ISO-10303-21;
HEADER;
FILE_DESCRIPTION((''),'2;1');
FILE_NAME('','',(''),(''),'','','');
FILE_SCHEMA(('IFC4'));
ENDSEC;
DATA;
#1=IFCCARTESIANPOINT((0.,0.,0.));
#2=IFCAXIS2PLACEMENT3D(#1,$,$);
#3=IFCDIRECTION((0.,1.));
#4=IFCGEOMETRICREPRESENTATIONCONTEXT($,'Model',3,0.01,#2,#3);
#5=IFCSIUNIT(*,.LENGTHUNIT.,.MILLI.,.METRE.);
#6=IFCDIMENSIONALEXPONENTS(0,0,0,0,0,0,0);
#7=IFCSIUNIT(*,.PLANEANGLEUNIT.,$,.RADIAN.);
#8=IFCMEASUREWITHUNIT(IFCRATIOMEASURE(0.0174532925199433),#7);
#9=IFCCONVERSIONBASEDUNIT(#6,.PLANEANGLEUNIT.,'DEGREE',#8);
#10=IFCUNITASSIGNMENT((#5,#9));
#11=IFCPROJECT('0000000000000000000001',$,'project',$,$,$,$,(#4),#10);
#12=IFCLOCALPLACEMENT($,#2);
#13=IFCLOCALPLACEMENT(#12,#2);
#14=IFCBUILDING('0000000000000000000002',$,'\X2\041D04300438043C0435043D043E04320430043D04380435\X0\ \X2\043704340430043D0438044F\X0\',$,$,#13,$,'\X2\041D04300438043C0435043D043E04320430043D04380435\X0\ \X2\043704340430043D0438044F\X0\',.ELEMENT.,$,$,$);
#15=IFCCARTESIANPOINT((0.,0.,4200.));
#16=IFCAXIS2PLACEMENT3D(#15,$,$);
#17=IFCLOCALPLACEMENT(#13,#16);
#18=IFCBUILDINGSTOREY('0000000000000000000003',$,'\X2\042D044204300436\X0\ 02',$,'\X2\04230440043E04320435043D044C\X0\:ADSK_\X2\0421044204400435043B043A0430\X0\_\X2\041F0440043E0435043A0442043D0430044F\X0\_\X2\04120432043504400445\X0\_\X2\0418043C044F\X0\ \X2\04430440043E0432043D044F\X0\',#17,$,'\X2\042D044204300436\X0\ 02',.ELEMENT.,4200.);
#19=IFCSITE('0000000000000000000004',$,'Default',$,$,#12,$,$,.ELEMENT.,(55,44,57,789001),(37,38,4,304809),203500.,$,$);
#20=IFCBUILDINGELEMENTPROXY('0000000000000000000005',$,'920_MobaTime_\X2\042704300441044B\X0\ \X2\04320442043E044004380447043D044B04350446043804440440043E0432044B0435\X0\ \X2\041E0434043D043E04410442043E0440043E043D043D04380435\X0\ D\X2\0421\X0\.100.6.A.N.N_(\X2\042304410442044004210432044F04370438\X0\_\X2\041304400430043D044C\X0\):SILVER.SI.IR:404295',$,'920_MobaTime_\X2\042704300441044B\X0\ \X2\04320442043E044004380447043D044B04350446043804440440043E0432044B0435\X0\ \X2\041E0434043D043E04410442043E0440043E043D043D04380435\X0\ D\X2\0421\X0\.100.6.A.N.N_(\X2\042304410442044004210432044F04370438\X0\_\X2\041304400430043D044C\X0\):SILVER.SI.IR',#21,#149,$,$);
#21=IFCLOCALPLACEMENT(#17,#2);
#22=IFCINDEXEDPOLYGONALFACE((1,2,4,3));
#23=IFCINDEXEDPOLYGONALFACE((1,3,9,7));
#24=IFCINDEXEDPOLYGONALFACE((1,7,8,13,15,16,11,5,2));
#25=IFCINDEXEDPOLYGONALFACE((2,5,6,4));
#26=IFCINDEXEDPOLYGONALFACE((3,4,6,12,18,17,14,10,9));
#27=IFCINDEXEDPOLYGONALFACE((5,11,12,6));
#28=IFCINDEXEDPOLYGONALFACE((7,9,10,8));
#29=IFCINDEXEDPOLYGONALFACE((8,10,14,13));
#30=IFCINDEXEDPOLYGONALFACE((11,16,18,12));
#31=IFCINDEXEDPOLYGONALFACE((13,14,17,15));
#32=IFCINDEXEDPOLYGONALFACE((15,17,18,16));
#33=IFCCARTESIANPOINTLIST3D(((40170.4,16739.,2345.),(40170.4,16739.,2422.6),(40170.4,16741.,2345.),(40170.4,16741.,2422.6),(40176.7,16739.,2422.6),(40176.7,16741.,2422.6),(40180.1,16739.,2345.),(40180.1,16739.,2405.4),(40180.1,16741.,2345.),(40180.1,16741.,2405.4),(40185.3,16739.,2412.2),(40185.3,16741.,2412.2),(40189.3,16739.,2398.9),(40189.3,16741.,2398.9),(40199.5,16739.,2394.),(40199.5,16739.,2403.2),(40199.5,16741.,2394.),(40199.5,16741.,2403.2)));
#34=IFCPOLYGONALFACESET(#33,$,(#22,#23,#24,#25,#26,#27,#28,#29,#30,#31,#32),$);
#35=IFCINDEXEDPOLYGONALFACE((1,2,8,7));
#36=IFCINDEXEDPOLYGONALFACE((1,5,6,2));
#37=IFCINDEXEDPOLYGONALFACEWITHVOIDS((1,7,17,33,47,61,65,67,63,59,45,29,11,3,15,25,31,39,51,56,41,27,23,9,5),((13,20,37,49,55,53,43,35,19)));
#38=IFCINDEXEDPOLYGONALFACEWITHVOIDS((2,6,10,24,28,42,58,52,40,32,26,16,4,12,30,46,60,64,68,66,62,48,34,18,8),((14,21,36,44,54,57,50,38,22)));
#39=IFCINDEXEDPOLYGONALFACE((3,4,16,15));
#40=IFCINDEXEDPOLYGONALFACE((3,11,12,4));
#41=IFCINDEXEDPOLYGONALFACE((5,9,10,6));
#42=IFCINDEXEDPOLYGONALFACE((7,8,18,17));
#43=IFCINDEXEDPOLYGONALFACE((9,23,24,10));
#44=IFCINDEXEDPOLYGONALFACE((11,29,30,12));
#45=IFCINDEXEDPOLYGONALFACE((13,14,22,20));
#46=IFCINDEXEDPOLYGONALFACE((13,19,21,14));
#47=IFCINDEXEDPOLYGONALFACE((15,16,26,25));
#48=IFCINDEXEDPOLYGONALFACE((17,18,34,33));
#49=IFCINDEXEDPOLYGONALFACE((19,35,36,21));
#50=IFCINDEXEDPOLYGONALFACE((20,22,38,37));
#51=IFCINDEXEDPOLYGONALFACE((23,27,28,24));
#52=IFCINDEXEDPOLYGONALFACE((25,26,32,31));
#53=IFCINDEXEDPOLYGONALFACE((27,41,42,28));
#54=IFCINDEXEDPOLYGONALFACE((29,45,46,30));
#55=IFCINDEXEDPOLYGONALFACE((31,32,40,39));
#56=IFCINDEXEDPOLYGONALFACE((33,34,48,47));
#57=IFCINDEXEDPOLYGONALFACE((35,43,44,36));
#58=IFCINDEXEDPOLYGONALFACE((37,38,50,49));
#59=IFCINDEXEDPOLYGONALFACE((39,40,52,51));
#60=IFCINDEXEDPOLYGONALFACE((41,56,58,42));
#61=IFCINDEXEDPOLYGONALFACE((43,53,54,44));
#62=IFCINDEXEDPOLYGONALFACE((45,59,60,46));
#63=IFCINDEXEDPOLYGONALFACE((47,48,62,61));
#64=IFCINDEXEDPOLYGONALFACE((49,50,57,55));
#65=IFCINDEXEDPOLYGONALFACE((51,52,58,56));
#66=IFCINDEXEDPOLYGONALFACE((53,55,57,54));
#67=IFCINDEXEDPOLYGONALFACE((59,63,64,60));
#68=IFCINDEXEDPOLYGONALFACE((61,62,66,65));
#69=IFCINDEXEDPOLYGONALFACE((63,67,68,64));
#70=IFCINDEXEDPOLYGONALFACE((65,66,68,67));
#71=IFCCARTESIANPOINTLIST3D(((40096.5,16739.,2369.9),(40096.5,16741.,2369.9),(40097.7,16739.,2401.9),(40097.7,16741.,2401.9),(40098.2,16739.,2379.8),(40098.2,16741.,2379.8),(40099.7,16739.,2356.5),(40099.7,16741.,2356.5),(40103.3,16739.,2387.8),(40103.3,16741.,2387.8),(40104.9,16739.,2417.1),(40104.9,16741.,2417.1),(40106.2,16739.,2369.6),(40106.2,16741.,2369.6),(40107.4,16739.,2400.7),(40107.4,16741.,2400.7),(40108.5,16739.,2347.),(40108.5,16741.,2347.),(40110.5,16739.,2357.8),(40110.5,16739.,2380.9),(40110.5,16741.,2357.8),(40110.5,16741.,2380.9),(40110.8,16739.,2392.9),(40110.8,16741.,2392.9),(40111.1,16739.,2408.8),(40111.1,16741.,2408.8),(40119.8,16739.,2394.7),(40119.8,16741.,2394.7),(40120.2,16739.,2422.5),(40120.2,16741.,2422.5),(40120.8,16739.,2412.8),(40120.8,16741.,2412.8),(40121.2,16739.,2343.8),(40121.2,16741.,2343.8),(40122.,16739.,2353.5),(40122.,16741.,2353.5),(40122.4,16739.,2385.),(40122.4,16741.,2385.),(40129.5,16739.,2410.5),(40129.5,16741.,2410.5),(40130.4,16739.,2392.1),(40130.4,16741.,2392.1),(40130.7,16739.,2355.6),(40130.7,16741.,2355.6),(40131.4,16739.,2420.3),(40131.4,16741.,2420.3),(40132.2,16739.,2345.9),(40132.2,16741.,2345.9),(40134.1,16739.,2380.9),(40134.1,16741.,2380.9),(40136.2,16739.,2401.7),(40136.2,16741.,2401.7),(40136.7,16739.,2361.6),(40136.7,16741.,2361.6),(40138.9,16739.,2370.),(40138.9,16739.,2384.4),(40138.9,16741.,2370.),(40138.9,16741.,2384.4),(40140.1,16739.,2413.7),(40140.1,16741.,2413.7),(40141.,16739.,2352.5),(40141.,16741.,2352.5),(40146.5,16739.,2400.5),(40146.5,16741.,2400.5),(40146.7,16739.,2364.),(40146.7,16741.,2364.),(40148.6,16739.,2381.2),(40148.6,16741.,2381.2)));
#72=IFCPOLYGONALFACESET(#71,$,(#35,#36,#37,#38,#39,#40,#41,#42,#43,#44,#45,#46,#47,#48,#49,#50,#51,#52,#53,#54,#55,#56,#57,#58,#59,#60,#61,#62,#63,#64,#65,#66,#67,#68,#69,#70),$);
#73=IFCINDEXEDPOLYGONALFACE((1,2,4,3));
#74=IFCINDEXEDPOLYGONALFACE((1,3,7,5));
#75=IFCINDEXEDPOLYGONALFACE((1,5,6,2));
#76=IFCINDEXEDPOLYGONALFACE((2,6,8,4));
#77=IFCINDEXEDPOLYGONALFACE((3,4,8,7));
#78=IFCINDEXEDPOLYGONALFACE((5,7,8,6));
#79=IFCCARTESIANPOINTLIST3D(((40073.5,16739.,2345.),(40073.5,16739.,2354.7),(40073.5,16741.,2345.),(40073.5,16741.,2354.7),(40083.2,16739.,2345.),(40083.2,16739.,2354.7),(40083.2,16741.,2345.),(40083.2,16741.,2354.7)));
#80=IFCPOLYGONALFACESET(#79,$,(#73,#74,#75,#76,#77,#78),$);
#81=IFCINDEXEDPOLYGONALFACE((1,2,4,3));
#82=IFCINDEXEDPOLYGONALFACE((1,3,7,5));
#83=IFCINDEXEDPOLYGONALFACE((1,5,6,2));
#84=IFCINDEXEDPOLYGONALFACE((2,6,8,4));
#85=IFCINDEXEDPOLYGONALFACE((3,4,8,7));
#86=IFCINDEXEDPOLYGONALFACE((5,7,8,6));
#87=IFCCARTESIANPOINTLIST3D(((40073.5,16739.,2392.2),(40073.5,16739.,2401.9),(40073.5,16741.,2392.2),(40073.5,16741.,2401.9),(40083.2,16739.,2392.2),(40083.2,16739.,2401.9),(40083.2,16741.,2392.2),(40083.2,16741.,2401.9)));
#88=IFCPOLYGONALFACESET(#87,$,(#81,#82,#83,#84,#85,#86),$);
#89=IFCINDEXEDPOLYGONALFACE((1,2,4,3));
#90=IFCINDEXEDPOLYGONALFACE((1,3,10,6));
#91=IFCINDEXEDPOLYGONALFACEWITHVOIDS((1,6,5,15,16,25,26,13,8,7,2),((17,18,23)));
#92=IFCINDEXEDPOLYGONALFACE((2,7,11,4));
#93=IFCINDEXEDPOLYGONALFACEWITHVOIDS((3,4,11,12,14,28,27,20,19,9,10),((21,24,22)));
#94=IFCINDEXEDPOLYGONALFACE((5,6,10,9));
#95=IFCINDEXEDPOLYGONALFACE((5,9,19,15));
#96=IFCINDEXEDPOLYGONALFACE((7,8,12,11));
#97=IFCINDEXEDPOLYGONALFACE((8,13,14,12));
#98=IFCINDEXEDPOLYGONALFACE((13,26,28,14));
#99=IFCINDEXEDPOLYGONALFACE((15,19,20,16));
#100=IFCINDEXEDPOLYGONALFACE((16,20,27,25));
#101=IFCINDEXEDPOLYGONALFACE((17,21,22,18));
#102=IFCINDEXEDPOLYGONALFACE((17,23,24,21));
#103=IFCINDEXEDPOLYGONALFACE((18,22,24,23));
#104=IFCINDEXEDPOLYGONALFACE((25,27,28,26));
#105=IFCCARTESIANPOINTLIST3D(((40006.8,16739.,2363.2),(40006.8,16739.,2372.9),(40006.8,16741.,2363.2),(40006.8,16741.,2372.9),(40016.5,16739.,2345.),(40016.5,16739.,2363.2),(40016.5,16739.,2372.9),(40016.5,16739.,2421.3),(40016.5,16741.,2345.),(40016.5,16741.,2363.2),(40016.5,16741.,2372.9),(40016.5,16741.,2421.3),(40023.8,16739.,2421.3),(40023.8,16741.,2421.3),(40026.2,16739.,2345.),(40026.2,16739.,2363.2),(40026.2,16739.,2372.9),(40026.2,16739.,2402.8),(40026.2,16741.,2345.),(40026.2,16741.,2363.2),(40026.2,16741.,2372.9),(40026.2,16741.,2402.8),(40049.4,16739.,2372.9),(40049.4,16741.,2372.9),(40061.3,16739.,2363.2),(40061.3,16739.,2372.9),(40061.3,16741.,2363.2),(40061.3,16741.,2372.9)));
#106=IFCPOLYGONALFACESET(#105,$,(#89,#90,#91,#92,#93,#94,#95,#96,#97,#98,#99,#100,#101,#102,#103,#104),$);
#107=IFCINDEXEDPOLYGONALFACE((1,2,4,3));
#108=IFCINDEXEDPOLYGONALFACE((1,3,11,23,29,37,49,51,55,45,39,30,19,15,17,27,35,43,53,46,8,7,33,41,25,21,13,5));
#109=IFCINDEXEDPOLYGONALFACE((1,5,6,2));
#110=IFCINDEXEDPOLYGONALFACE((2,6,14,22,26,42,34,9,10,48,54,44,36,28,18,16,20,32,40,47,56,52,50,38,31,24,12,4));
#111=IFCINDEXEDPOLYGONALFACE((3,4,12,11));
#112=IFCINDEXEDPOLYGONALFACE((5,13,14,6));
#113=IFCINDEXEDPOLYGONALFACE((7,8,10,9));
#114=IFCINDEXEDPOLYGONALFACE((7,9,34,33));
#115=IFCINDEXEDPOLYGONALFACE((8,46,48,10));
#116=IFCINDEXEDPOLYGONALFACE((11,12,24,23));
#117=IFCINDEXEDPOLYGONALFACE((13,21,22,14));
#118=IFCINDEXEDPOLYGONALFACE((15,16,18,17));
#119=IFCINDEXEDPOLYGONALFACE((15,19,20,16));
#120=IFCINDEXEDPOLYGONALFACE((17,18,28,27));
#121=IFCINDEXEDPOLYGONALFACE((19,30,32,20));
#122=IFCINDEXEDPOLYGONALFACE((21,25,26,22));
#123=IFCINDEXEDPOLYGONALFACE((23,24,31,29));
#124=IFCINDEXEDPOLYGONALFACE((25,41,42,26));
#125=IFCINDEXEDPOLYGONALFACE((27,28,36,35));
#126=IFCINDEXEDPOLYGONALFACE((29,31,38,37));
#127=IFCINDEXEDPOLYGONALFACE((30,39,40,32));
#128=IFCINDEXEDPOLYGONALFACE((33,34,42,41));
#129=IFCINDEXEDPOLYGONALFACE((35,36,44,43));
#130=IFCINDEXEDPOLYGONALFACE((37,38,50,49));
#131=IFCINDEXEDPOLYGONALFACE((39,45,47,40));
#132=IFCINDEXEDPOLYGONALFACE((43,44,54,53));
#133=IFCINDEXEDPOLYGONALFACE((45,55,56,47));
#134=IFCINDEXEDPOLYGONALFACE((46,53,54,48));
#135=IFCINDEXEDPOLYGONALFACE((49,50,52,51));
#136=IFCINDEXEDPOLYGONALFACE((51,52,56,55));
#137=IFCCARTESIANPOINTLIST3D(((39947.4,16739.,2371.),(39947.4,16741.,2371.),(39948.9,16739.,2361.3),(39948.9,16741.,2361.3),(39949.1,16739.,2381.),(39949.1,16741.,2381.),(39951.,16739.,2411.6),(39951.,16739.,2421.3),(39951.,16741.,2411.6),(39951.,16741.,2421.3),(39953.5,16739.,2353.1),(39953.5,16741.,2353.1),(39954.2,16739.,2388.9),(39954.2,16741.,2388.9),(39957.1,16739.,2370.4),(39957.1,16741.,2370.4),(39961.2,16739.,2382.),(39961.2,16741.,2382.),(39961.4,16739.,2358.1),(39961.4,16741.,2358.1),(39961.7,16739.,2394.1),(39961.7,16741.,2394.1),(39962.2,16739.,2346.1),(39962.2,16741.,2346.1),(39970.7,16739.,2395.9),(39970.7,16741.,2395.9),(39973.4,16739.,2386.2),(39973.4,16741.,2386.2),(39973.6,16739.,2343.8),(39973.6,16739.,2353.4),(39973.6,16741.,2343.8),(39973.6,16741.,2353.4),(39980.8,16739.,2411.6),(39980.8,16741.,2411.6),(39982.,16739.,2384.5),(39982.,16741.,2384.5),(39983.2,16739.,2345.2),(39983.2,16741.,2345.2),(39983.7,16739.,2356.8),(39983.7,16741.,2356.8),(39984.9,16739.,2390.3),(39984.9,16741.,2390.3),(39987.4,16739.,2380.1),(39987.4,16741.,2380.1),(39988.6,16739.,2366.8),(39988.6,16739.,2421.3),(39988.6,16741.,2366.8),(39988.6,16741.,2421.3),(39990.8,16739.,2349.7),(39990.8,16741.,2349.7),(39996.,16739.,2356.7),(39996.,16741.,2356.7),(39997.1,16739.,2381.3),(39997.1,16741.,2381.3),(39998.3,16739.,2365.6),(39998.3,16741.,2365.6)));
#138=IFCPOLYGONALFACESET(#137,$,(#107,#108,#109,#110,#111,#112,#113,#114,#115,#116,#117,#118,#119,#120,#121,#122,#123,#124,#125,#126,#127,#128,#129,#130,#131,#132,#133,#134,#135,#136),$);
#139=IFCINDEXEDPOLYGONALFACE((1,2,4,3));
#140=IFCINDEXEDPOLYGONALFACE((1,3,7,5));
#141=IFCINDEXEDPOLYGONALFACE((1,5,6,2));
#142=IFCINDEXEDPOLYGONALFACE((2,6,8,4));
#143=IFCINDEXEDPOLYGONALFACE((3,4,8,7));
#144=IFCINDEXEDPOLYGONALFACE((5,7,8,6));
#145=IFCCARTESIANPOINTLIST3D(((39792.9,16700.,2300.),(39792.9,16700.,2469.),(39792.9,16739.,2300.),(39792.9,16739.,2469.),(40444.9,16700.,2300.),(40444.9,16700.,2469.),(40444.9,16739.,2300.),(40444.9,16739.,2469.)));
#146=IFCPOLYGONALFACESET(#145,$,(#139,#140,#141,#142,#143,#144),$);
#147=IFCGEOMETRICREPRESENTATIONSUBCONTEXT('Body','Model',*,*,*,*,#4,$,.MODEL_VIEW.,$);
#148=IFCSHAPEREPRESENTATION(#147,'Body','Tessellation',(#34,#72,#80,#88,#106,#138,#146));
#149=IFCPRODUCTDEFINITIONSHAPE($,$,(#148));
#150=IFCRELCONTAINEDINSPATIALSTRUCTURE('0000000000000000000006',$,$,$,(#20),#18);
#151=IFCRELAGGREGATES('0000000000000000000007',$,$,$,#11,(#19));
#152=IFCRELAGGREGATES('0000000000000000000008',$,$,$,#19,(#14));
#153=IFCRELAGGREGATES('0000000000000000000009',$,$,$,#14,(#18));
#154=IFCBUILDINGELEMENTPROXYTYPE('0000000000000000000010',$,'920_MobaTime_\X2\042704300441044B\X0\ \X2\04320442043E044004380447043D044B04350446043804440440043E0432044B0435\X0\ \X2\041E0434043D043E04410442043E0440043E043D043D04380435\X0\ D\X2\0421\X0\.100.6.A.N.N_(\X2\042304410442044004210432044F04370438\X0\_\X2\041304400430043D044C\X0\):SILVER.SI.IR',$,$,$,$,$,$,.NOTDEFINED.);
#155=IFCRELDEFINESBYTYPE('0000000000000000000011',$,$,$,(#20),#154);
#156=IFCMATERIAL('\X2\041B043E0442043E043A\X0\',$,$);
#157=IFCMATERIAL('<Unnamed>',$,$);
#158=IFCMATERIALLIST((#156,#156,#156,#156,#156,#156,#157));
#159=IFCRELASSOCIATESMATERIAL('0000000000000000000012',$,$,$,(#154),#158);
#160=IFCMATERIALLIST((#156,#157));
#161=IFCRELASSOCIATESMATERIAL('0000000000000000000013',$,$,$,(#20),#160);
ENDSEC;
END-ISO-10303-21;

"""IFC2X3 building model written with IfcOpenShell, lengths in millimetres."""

from ifc_helpers import new_model, entity, si_unit, converted_unit, direction, frame, origin, origin_2d_with_axis, place, context, subcontext, project, spatial, polyline, rectangle, outline, extrude, source, transform, mapped, material, material_list, type_object, type_shapes, element, save


model = new_model("IFC2X3")

# Units and contexts
model_context = context("Model", 3, precision=0.01, world=origin(), true_north=direction((0.0, 1.0)))
body_context = subcontext(model_context, "Body", "Model", "MODEL_VIEW")
ifc_project = project(units=[si_unit("LENGTHUNIT", "METRE", prefix="MILLI"), converted_unit("PLANEANGLEUNIT", "DEGREE", entity("IfcRatioMeasure", 0.0174532925199433), si_unit("PLANEANGLEUNIT", "RADIAN"), dimensions=[0, 0, 0, 0, 0, 0, 0])], contexts=[model_context])

# Site, building, storey
site_placement = place(None, origin())
site = spatial("IfcSite", under=ifc_project, at=site_placement, Name="Default", CompositionType="ELEMENT", RefLatitude=(55, 44, 57, 789001), RefLongitude=(37, 38, 4, 304809), RefElevation=203500.0)
building_placement = place(site_placement, origin())
building = spatial("IfcBuilding", under=site, at=building_placement, Name="Наименование здания", LongName="Наименование здания", CompositionType="ELEMENT")
storey_placement = place(building_placement, frame((0.0, 0.0, 4200.0)))
storey = spatial("IfcBuildingStorey", under=building, at=storey_placement, Name="Этаж 02", ObjectType="Уровень:ADSK_Стрелка_Проектная_Вверх_Имя уровня", LongName="Этаж 02", CompositionType="ELEMENT", Elevation=4200.0)

# Building element proxy
ifc_material_1 = material(Name="Лоток")
ifc_material_2 = material(Name="<Unnamed>")
ifc_material_list_1 = material_list([ifc_material_1, ifc_material_2])
ifc_material_list_2 = material_list([ifc_material_1, ifc_material_1, ifc_material_1, ifc_material_1, ifc_material_1, ifc_material_1, ifc_material_2])
building_element_proxy_type_1 = type_object("IfcBuildingElementProxyType", Name="920_MobaTime_Часы вторичныецифровые Односторонние DС.100.6.A.N.N_(УстрСвязи_Грань):SILVER.SI.IR", PredefinedType="NOTDEFINED", material=ifc_material_list_2)
shared_shape_1 = source(origin(), body_context, "Body", "SweptSolid", [
    extrude(outline(polyline([(-49.3, -13.1), (28.2, -13.1), (28.2, -6.8), (17.9, 1.8), (8.8, 16.0), (-0.3, 16.0), (4.6, 5.8), (11.1, -3.4), (-49.3, -3.4), (-49.3, -13.1)])), frame((-64.6, 9.8, 39.0), z_axis=(0.0, 0.0, 1.0), x_axis=(0.0, 1.0, 0.0)), (0.0, 0.0, 1.0), 2.0),
    extrude(outline(polyline([(2.2, -27.6), (19.0, -27.6), (30.5, -16.1), (33.3, -4.9), (31.0, 5.8), (21.8, 17.2), (5.2, 27.3), (-11.1, 33.0), (-24.0, 32.7), (-33.6, 27.6), (-40.3, 18.6), (-42.8, 5.7), (-38.0, -6.3), (-27.2, -14.9), (-17.5, -17.7), (-8.2, -16.4), (-0.3, -11.9), (5.1, -4.5), (7.3, 6.2), (4.0, 17.2), (18.4, 7.3), (23.6, -2.4), (22.0, -11.4), (14.2, -18.4), (5.3, -18.3), (2.2, -27.6)]), holes=[polyline([(-9.0, 23.3), (-1.3, 14.3), (-2.5, 2.0), (-11.4, -7.0), (-23.4, -6.0), (-32.2, 2.9), (-31.2, 15.1), (-25.6, 22.1), (-17.5, 24.9), (-9.0, 23.3)])]), frame((-2.7, 3.6, 39.0), z_axis=(0.0, 0.0, 1.0), x_axis=(-0.427649, 0.903945, 0.0)), (0.0, 0.0, 1.0), 2.0),
    extrude(rectangle(XDim=9.7, YDim=9.7, at=origin_2d_with_axis()), frame((40.6, -34.7, 39.0)), (0.0, 0.0, 1.0), 2.0),
    extrude(rectangle(XDim=9.7, YDim=9.7, at=origin_2d_with_axis()), frame((40.6, 12.6, 39.0)), (0.0, 0.0, 1.0), 2.0),
    extrude(outline(polyline([(-0.9, -28.1), (8.8, -28.1), (8.8, -9.9), (18.5, -9.9), (18.5, -0.2), (8.8, -0.2), (8.8, 48.3), (1.5, 48.3), (-36.0, -0.2), (-36.0, -9.9), (-0.9, -9.9), (-0.9, -28.1)]), holes=[polyline([(-0.9, -0.2), (-24.1, -0.2), (-0.9, 29.7), (-0.9, -0.2)])]), frame((93.6, -11.4, 39.0)), (0.0, 0.0, 1.0), 2.0),
    extrude(outline(polyline([(3.3, -28.3), (12.5, -28.3), (20.5, -25.0), (26.8, -18.9), (30.7, -10.0), (31.4, 1.6), (26.9, 11.8), (20.1, 18.4), (11.1, 22.3), (1.0, 23.3), (-7.9, 20.4), (-14.9, 14.5), (-18.9, 6.2), (-17.1, -9.0), (-36.7, 0.5), (-29.1, 29.2), (-38.5, 31.7), (-48.1, -4.6), (-11.6, -23.1), (-8.0, -14.0), (-10.8, -7.6), (-10.2, 1.1), (-3.0, 11.8), (9.2, 12.8), (20.0, 5.5), (21.4, -7.5), (15.5, -16.4), (4.6, -18.6), (3.3, -28.3)])), frame((147.1, -8.5, 39.0), z_axis=(0.0, 0.0, 1.0), x_axis=(0.256974, -0.966418, 0.0)), (0.0, 0.0, 1.0), 2.0),
    extrude(rectangle(XDim=652.0, YDim=169.0, at=origin_2d_with_axis()), frame((0.0, 0.0, 0.0), z_axis=(0.0, 0.0, 1.0), x_axis=(-1.0, 0.0, 0.0)), (0.0, 0.0, 1.0), 39.0),
])
type_shapes(building_element_proxy_type_1, [shared_shape_1])
for number, where, z_axis, x_axis, name in (
    (1, (40118.9, 16700.0, 2384.5), (0.0, 1.0, 0.0), (-1.0, 0.0, 0.0), "920_MobaTime_Часы вторичныецифровые Односторонние DС.100.6.A.N.N_(УстрСвязи_Грань):SILVER.SI.IR:404295"),
):
    element("IfcBuildingElementProxy", number, at=place(storey_placement, frame(where, z_axis=z_axis, x_axis=x_axis)), inside=storey, type_object=building_element_proxy_type_1, material=ifc_material_list_1, Name=name, ObjectType="920_MobaTime_Часы вторичныецифровые Односторонние DС.100.6.A.N.N_(УстрСвязи_Грань):SILVER.SI.IR", context=body_context, shape_type="MappedRepresentation", body=[
        mapped(shared_shape_1, transform((0.0, 0.0, 0.0), scale=1.0)),
    ])

save(model, "model.ifc")
